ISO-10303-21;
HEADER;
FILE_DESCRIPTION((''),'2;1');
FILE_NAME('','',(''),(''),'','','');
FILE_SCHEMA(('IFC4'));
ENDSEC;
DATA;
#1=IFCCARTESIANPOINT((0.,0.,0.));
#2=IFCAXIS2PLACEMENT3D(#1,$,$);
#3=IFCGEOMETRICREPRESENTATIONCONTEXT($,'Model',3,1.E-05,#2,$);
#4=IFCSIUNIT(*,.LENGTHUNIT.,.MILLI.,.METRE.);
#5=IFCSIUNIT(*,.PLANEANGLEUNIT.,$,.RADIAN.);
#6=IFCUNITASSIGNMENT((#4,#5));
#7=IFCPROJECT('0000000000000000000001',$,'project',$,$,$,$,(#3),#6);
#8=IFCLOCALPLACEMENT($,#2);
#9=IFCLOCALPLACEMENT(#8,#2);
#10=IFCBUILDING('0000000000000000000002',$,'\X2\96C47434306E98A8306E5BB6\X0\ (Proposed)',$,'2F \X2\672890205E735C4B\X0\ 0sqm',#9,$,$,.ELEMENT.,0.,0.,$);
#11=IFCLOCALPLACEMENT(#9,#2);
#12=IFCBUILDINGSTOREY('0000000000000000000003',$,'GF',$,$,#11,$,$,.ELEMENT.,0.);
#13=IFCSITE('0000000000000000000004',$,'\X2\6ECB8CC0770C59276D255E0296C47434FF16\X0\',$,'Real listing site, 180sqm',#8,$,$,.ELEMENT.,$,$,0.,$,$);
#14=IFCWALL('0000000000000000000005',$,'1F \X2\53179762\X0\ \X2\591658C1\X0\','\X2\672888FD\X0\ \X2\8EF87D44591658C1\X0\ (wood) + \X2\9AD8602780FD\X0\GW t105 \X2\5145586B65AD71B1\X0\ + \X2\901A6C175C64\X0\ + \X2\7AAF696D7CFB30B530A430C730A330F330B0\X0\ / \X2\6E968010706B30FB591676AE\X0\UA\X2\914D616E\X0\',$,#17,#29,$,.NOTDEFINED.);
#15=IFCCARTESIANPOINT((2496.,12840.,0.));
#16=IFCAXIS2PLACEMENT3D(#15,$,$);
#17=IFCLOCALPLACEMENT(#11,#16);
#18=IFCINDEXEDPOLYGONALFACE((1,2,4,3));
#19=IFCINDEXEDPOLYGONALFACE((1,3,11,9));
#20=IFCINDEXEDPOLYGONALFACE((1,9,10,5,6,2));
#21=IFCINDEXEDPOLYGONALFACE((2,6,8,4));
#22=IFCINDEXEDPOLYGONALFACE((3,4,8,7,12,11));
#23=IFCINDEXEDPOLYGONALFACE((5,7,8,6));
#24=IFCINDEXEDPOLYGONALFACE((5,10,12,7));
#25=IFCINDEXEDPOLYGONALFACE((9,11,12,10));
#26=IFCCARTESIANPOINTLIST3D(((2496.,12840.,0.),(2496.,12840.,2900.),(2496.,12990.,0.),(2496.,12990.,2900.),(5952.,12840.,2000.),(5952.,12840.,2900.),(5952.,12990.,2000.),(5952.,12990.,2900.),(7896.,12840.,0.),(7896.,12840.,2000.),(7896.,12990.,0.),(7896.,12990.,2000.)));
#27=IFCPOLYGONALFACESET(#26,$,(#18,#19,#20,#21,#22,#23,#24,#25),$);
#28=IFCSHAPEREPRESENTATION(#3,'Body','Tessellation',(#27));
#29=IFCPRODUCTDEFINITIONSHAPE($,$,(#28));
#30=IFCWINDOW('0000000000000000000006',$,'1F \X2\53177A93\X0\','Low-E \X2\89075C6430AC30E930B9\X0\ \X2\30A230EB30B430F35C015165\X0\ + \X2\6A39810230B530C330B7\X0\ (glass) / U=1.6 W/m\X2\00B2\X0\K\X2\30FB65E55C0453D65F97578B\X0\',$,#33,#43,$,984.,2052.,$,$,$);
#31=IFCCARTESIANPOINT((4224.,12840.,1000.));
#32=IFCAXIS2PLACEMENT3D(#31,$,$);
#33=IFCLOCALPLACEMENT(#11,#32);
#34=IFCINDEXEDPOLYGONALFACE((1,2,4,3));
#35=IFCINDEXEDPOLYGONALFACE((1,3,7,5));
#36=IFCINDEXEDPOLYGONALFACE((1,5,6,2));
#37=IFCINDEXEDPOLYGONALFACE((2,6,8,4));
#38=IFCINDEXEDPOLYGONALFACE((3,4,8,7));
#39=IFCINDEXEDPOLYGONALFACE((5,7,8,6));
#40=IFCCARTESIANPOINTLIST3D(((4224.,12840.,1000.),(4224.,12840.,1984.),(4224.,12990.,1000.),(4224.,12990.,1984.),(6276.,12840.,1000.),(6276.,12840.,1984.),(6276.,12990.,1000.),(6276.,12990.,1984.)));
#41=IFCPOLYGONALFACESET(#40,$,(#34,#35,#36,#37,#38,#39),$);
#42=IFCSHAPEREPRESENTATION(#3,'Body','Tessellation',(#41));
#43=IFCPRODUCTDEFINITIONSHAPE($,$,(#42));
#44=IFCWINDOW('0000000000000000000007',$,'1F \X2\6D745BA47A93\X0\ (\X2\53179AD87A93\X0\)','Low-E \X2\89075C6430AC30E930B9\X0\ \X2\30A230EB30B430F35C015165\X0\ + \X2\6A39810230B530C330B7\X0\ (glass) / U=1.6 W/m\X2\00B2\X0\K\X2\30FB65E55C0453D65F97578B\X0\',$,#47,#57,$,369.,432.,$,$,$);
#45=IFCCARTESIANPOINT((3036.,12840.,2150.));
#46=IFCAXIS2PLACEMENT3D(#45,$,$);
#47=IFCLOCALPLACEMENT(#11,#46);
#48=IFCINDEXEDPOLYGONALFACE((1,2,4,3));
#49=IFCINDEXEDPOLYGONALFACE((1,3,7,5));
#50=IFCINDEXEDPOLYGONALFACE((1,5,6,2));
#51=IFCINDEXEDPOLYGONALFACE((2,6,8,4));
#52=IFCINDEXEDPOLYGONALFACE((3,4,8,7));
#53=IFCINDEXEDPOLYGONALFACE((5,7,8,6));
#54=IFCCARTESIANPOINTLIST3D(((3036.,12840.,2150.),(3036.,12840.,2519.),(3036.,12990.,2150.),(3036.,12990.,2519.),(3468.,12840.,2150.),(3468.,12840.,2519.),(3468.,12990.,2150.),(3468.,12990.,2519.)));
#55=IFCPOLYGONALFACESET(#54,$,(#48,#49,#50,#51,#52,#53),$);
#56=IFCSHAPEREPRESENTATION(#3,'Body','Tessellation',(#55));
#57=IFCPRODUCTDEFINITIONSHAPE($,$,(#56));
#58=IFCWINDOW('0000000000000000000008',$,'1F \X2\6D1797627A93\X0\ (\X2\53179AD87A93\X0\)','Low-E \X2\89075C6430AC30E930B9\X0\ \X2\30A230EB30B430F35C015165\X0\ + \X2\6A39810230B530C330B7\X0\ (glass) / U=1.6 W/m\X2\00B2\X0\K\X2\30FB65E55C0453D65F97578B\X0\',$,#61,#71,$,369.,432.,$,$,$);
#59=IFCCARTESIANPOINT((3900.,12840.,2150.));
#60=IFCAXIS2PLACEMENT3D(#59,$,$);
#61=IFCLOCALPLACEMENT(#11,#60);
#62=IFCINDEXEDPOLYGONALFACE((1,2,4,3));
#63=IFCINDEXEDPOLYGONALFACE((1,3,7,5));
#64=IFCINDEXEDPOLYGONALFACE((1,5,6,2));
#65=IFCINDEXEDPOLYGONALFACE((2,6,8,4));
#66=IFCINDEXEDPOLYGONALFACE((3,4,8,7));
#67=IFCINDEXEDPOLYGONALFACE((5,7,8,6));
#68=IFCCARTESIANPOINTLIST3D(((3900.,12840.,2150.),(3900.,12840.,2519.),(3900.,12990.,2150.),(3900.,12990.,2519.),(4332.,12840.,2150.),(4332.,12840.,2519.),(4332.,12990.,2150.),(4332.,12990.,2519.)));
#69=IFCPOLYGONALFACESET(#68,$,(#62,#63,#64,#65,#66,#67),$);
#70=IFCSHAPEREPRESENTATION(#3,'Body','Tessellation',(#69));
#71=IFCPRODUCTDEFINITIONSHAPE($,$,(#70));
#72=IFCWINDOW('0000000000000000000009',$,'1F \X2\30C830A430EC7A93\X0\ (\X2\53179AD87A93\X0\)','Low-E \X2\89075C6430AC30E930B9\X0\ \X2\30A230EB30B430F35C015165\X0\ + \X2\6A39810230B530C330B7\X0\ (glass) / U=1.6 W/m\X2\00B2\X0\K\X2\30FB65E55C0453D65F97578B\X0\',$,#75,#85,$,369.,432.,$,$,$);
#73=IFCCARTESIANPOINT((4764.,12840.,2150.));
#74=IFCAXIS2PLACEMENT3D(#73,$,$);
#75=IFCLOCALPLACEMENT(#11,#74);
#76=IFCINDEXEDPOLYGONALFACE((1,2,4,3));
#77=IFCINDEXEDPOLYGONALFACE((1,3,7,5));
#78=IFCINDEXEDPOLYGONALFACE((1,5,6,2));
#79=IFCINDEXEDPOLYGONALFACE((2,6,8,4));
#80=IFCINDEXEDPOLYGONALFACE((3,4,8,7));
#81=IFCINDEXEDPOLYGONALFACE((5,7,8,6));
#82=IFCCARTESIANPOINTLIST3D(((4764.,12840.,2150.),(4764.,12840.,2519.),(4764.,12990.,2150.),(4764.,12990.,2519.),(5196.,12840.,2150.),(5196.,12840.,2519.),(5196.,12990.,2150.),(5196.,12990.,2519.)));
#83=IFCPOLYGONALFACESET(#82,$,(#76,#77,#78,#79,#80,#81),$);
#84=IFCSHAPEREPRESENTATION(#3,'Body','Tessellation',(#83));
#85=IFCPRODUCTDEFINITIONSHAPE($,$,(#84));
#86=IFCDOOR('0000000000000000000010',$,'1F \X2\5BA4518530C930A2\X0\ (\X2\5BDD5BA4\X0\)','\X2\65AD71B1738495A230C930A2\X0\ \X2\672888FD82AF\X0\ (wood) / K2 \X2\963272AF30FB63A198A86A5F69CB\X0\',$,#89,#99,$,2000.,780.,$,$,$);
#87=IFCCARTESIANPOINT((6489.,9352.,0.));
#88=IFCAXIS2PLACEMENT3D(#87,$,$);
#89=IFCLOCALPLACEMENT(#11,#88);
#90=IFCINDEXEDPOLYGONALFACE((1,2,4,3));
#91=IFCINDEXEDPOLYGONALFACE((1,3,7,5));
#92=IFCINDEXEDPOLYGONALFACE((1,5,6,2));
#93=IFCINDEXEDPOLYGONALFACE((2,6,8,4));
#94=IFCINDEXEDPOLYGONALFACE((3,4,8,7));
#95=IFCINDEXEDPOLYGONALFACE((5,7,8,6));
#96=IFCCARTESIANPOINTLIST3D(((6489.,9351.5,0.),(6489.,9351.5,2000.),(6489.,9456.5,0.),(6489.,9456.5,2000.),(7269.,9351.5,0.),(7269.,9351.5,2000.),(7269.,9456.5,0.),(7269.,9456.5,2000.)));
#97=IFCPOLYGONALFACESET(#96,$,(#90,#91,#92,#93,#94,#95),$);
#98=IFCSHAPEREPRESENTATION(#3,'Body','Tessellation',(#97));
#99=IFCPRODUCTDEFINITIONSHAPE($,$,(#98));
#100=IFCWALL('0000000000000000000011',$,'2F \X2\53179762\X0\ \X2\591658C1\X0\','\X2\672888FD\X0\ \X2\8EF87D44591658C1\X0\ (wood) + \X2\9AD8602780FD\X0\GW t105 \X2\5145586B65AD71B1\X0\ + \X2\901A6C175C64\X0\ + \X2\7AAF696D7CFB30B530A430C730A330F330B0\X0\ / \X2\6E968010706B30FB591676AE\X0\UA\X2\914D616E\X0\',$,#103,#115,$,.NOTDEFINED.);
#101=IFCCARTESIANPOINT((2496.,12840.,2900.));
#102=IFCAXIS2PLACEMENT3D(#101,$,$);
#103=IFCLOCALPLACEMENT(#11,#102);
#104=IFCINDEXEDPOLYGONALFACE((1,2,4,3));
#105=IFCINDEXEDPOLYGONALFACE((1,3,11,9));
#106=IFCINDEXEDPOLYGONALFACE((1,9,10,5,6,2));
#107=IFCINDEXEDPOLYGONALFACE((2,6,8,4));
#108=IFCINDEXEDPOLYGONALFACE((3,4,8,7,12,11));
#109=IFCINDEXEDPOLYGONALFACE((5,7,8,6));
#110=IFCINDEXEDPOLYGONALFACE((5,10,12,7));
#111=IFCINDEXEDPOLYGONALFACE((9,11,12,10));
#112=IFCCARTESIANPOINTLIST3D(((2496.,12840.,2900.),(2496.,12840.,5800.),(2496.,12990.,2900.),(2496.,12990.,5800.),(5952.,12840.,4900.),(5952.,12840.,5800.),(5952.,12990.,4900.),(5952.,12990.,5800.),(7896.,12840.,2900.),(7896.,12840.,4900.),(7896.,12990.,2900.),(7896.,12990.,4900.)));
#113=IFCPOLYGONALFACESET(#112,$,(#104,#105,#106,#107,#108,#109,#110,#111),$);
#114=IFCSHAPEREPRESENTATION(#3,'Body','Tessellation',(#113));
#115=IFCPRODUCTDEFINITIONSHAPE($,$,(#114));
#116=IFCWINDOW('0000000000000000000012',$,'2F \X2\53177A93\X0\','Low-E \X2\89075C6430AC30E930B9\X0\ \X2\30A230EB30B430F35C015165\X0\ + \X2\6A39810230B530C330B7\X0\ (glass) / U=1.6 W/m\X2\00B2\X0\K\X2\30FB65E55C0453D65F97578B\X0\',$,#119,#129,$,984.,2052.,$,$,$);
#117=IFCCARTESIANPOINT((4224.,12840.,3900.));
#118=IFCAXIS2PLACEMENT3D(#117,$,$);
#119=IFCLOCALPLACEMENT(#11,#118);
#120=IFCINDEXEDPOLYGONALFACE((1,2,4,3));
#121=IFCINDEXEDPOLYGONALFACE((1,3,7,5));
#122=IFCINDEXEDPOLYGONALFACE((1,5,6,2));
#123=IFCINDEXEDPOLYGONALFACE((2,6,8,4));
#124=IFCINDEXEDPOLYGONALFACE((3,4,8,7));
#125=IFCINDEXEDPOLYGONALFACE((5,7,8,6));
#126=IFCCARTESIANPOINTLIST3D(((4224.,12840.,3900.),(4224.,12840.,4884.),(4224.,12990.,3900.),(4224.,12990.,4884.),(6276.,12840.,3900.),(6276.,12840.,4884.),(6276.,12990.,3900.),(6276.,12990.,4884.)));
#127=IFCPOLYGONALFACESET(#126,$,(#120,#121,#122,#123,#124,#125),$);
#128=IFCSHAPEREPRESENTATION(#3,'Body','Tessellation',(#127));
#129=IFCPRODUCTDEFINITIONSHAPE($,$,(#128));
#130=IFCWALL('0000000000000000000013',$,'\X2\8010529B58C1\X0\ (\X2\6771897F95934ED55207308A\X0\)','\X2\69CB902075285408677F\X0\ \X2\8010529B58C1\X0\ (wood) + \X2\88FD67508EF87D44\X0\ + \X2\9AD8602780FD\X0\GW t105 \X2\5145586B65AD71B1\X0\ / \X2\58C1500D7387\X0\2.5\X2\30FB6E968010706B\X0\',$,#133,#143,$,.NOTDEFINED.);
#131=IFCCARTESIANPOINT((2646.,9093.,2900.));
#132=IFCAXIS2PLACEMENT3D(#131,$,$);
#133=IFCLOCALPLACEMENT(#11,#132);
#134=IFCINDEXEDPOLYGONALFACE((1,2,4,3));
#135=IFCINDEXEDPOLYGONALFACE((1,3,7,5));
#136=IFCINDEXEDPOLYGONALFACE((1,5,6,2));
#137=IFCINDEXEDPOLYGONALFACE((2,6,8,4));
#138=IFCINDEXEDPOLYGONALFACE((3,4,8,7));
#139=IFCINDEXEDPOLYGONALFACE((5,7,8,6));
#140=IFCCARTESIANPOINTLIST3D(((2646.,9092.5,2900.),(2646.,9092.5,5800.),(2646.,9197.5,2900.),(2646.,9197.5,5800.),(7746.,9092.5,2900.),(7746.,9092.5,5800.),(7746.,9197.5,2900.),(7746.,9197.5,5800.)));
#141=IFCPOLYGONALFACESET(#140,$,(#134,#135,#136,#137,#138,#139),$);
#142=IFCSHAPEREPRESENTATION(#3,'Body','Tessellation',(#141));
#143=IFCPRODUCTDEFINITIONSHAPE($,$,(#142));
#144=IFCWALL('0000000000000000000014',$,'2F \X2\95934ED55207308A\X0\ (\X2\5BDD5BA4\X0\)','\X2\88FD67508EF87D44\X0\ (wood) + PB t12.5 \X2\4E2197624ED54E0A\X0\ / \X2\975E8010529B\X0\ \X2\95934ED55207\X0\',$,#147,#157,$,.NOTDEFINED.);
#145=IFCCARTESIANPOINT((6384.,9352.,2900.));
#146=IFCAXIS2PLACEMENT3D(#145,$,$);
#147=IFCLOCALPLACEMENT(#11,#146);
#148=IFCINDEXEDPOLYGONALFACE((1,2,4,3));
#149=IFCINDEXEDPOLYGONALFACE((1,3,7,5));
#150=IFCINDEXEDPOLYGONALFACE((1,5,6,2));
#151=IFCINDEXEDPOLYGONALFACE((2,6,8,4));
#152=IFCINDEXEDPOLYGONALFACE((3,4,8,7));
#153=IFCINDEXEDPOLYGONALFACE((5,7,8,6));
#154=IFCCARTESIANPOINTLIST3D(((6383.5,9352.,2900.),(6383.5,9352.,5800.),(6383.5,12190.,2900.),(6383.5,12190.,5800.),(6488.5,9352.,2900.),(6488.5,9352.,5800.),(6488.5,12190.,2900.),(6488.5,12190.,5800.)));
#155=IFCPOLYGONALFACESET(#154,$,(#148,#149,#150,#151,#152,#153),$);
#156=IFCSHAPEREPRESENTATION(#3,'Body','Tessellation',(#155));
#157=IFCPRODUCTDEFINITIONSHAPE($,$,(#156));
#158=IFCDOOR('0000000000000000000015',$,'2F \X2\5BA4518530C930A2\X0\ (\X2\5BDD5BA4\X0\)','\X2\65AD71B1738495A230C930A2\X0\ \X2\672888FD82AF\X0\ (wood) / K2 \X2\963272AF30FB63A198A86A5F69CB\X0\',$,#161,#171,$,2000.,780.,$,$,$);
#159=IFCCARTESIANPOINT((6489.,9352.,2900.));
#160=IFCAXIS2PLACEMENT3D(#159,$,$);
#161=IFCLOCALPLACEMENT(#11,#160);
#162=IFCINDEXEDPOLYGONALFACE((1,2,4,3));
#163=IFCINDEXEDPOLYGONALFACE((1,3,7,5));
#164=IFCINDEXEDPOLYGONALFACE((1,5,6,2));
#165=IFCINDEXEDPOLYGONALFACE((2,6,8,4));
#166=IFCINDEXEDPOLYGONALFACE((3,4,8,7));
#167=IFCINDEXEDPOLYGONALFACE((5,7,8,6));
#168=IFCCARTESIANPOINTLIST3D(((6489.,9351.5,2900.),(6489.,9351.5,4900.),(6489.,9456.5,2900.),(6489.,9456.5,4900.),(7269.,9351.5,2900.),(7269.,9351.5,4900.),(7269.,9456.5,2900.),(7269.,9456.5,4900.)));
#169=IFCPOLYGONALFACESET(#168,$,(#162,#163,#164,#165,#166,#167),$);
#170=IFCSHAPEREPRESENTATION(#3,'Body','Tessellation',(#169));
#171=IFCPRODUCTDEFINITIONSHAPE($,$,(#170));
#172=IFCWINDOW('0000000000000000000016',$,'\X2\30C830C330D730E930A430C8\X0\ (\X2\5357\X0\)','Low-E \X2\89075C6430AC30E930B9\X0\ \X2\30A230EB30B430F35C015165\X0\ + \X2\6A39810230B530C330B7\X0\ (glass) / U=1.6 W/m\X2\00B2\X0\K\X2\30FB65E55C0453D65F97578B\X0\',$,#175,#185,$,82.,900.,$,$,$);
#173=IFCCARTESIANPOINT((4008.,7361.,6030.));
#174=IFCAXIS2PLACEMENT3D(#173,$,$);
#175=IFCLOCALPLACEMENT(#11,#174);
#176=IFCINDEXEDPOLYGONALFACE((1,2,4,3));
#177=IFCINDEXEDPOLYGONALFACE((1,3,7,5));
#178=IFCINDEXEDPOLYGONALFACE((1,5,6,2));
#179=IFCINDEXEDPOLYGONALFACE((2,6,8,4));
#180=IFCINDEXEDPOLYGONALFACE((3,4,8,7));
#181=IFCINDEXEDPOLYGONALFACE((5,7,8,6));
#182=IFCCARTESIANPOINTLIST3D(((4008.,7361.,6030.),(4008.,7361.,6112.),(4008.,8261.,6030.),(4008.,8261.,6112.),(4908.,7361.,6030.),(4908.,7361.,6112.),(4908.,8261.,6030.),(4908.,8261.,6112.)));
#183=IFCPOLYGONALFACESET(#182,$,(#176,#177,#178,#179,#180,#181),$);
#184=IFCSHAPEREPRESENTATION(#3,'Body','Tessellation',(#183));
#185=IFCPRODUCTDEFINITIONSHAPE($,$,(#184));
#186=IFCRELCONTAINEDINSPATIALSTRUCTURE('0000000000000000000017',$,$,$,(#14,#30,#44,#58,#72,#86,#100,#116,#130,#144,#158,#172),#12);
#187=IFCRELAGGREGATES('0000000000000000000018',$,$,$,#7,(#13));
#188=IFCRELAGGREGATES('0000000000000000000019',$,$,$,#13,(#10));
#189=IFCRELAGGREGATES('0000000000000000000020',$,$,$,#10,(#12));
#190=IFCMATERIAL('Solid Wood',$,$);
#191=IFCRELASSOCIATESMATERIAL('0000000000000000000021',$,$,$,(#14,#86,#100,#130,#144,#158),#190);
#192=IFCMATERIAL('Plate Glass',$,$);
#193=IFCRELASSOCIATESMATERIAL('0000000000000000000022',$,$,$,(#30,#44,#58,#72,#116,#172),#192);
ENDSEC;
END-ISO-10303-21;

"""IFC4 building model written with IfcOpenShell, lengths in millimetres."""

from ifc_helpers import new_model, si_unit, frame, frame_2d, origin, place, context, project, spatial, rectangle, extrude, material, element, fill, save


model = new_model("IFC4")

# Units and contexts
model_context = context("Model", 3, precision=1e-05, world=origin())
ifc_project = project(units=[si_unit("LENGTHUNIT", "METRE", prefix="MILLI"), si_unit("PLANEANGLEUNIT", "RADIAN")], contexts=[model_context])

# Site, building, storey
site_placement = place(None, origin())
site = spatial("IfcSite", under=ifc_project, at=site_placement, Name="滋賀県大津市雄琴６", ObjectType="Real listing site, 180sqm", CompositionType="ELEMENT", RefElevation=0.0)
building_placement = place(site_placement, origin())
building = spatial("IfcBuilding", under=site, at=building_placement, Name="雄琴の風の家 (Proposed)", ObjectType="2F 木造平屋 0sqm", CompositionType="ELEMENT", ElevationOfRefHeight=0.0, ElevationOfTerrain=0.0)
storey_placement = place(building_placement, origin())
storey = spatial("IfcBuildingStorey", under=building, at=storey_placement, Name="GF", CompositionType="ELEMENT", Elevation=0.0)

# Wall, openings, windows
ifc_material_1 = material(Name="Solid Wood")
wall_1_placement = place(storey_placement, frame((2496.0, 12840.0, 0.0)))
wall_1 = element("IfcWall", 1, at=wall_1_placement, inside=storey, material=ifc_material_1, Name="1F 北面 外壁", Description="木製 軸組外壁 (wood) + 高性能GW t105 充填断熱 + 通気層 + 窯業系サイディング / 準耐火・外皮UA配慮", PredefinedType="NOTDEFINED", context=model_context, shape_type="SweptSolid", body=[
    extrude(rectangle(XDim=5400.0, YDim=150.0, at=frame_2d((2700.0, 75.0))), frame((2496.0, 12840.0, 0.0)), (0.0, 0.0, 1.0), 2900.0),
])
opening_1_placement = place(storey_placement, frame((4224.0, 12840.0, 1000.0)))
opening_1 = element("IfcOpeningElement", 2, at=opening_1_placement, cuts=wall_1, PredefinedType="NOTDEFINED", context=model_context, shape_type="SweptSolid", body=[
    extrude(rectangle(XDim=2052.0, YDim=150.0, at=frame_2d((1026.0, 75.0))), frame((4224.0, 12840.0, 1000.0)), (0.0, 0.0, 1.0), 984.0),
])
opening_2_placement = place(storey_placement, frame((3036.0, 12840.0, 2150.0)))
opening_2 = element("IfcOpeningElement", 3, at=opening_2_placement, cuts=wall_1, PredefinedType="NOTDEFINED", context=model_context, shape_type="SweptSolid", body=[
    extrude(rectangle(XDim=432.0, YDim=150.0, at=frame_2d((216.0, 75.0))), frame((3036.0, 12840.0, 2150.0)), (0.0, 0.0, 1.0), 369.0),
])
opening_3_placement = place(storey_placement, frame((3900.0, 12840.0, 2150.0)))
opening_3 = element("IfcOpeningElement", 4, at=opening_3_placement, cuts=wall_1, PredefinedType="NOTDEFINED", context=model_context, shape_type="SweptSolid", body=[
    extrude(rectangle(XDim=432.0, YDim=150.0, at=frame_2d((216.0, 75.0))), frame((3900.0, 12840.0, 2150.0)), (0.0, 0.0, 1.0), 369.0),
])
opening_4_placement = place(storey_placement, frame((4764.0, 12840.0, 2150.0)))
opening_4 = element("IfcOpeningElement", 5, at=opening_4_placement, cuts=wall_1, PredefinedType="NOTDEFINED", context=model_context, shape_type="SweptSolid", body=[
    extrude(rectangle(XDim=432.0, YDim=150.0, at=frame_2d((216.0, 75.0))), frame((4764.0, 12840.0, 2150.0)), (0.0, 0.0, 1.0), 369.0),
])
ifc_material_2 = material(Name="Plate Glass")
window_1_placement = place(storey_placement, frame((4224.0, 12840.0, 1000.0)))
window_1 = element("IfcWindow", 6, at=window_1_placement, inside=storey, material=ifc_material_2, Name="1F 北窓", Description="Low-E 複層ガラス アルゴン封入 + 樹脂サッシ (glass) / U=1.6 W/m²K・日射取得型", OverallHeight=984.0, OverallWidth=2052.0, context=model_context, shape_type="SweptSolid", body=[
    extrude(rectangle(XDim=2052.0, YDim=150.0, at=frame_2d((1026.0, 75.0))), frame((4224.0, 12840.0, 1000.0)), (0.0, 0.0, 1.0), 984.0),
])
fill(opening_1, window_1)
window_2_placement = place(storey_placement, frame((3036.0, 12840.0, 2150.0)))
window_2 = element("IfcWindow", 7, at=window_2_placement, inside=storey, material=ifc_material_2, Name="1F 浴室窓 (北高窓)", Description="Low-E 複層ガラス アルゴン封入 + 樹脂サッシ (glass) / U=1.6 W/m²K・日射取得型", OverallHeight=369.0, OverallWidth=432.0, context=model_context, shape_type="SweptSolid", body=[
    extrude(rectangle(XDim=432.0, YDim=150.0, at=frame_2d((216.0, 75.0))), frame((3036.0, 12840.0, 2150.0)), (0.0, 0.0, 1.0), 369.0),
])
fill(opening_2, window_2)
window_3_placement = place(storey_placement, frame((3900.0, 12840.0, 2150.0)))
window_3 = element("IfcWindow", 8, at=window_3_placement, inside=storey, material=ifc_material_2, Name="1F 洗面窓 (北高窓)", Description="Low-E 複層ガラス アルゴン封入 + 樹脂サッシ (glass) / U=1.6 W/m²K・日射取得型", OverallHeight=369.0, OverallWidth=432.0, context=model_context, shape_type="SweptSolid", body=[
    extrude(rectangle(XDim=432.0, YDim=150.0, at=frame_2d((216.0, 75.0))), frame((3900.0, 12840.0, 2150.0)), (0.0, 0.0, 1.0), 369.0),
])
fill(opening_3, window_3)
window_4_placement = place(storey_placement, frame((4764.0, 12840.0, 2150.0)))
window_4 = element("IfcWindow", 9, at=window_4_placement, inside=storey, material=ifc_material_2, Name="1F トイレ窓 (北高窓)", Description="Low-E 複層ガラス アルゴン封入 + 樹脂サッシ (glass) / U=1.6 W/m²K・日射取得型", OverallHeight=369.0, OverallWidth=432.0, context=model_context, shape_type="SweptSolid", body=[
    extrude(rectangle(XDim=432.0, YDim=150.0, at=frame_2d((216.0, 75.0))), frame((4764.0, 12840.0, 2150.0)), (0.0, 0.0, 1.0), 369.0),
])
fill(opening_4, window_4)

# Door
door_1_placement = place(storey_placement, frame((6489.0, 9352.0, 0.0)))
element("IfcDoor", 10, at=door_1_placement, inside=storey, material=ifc_material_1, Name="1F 室内ドア (寝室)", Description="断熱玄関ドア 木製芯 (wood) / K2 防犯・採風機構", OverallHeight=2000.0, OverallWidth=780.0, context=model_context, shape_type="SweptSolid", body=[
    extrude(rectangle(XDim=780.0, YDim=105.0, at=frame_2d((390.0, 52.0))), frame((6489.0, 9352.0, 0.0)), (0.0, 0.0, 1.0), 2000.0),
])

# Wall, opening, window
wall_2_placement = place(storey_placement, frame((2496.0, 12840.0, 2900.0)))
wall_2 = element("IfcWall", 11, at=wall_2_placement, inside=storey, material=ifc_material_1, Name="2F 北面 外壁", Description="木製 軸組外壁 (wood) + 高性能GW t105 充填断熱 + 通気層 + 窯業系サイディング / 準耐火・外皮UA配慮", PredefinedType="NOTDEFINED", context=model_context, shape_type="SweptSolid", body=[
    extrude(rectangle(XDim=5400.0, YDim=150.0, at=frame_2d((2700.0, 75.0))), frame((2496.0, 12840.0, 2900.0)), (0.0, 0.0, 1.0), 2900.0),
])
opening_5_placement = place(storey_placement, frame((4224.0, 12840.0, 3900.0)))
opening_5 = element("IfcOpeningElement", 12, at=opening_5_placement, cuts=wall_2, PredefinedType="NOTDEFINED", context=model_context, shape_type="SweptSolid", body=[
    extrude(rectangle(XDim=2052.0, YDim=150.0, at=frame_2d((1026.0, 75.0))), frame((4224.0, 12840.0, 3900.0)), (0.0, 0.0, 1.0), 984.0),
])
window_5_placement = place(storey_placement, frame((4224.0, 12840.0, 3900.0)))
window_5 = element("IfcWindow", 13, at=window_5_placement, inside=storey, material=ifc_material_2, Name="2F 北窓", Description="Low-E 複層ガラス アルゴン封入 + 樹脂サッシ (glass) / U=1.6 W/m²K・日射取得型", OverallHeight=984.0, OverallWidth=2052.0, context=model_context, shape_type="SweptSolid", body=[
    extrude(rectangle(XDim=2052.0, YDim=150.0, at=frame_2d((1026.0, 75.0))), frame((4224.0, 12840.0, 3900.0)), (0.0, 0.0, 1.0), 984.0),
])
fill(opening_5, window_5)

# Walls
wall_3_placement = place(storey_placement, frame((2646.0, 9093.0, 2900.0)))
element("IfcWall", 14, at=wall_3_placement, inside=storey, material=ifc_material_1, Name="耐力壁 (東西間仕切り)", Description="構造用合板 耐力壁 (wood) + 製材軸組 + 高性能GW t105 充填断熱 / 壁倍率2.5・準耐火", PredefinedType="NOTDEFINED", context=model_context, shape_type="SweptSolid", body=[
    extrude(rectangle(XDim=5100.0, YDim=105.0, at=frame_2d((2550.0, 52.0))), frame((2646.0, 9093.0, 2900.0)), (0.0, 0.0, 1.0), 2900.0),
])
wall_4_placement = place(storey_placement, frame((6384.0, 9352.0, 2900.0)))
element("IfcWall", 15, at=wall_4_placement, inside=storey, material=ifc_material_1, Name="2F 間仕切り (寝室)", Description="製材軸組 (wood) + PB t12.5 両面仕上 / 非耐力 間仕切", PredefinedType="NOTDEFINED", context=model_context, shape_type="SweptSolid", body=[
    extrude(rectangle(XDim=105.0, YDim=2838.0, at=frame_2d((52.0, 1419.0))), frame((6384.0, 9352.0, 2900.0)), (0.0, 0.0, 1.0), 2900.0),
])

# Door
door_2_placement = place(storey_placement, frame((6489.0, 9352.0, 2900.0)))
element("IfcDoor", 16, at=door_2_placement, inside=storey, material=ifc_material_1, Name="2F 室内ドア (寝室)", Description="断熱玄関ドア 木製芯 (wood) / K2 防犯・採風機構", OverallHeight=2000.0, OverallWidth=780.0, context=model_context, shape_type="SweptSolid", body=[
    extrude(rectangle(XDim=780.0, YDim=105.0, at=frame_2d((390.0, 52.0))), frame((6489.0, 9352.0, 2900.0)), (0.0, 0.0, 1.0), 2000.0),
])

# Window
window_6_placement = place(storey_placement, frame((4008.0, 7361.0, 6030.0)))
element("IfcWindow", 17, at=window_6_placement, inside=storey, material=ifc_material_2, Name="トップライト (南)", Description="Low-E 複層ガラス アルゴン封入 + 樹脂サッシ (glass) / U=1.6 W/m²K・日射取得型", OverallHeight=82.0, OverallWidth=900.0, context=model_context, shape_type="SweptSolid", body=[
    extrude(rectangle(XDim=900.0, YDim=900.0, at=frame_2d((450.0, 450.0))), frame((4008.0, 7361.0, 6030.0)), (0.0, 0.0, 1.0), 82.0),
])

save(model, "model.ifc")
